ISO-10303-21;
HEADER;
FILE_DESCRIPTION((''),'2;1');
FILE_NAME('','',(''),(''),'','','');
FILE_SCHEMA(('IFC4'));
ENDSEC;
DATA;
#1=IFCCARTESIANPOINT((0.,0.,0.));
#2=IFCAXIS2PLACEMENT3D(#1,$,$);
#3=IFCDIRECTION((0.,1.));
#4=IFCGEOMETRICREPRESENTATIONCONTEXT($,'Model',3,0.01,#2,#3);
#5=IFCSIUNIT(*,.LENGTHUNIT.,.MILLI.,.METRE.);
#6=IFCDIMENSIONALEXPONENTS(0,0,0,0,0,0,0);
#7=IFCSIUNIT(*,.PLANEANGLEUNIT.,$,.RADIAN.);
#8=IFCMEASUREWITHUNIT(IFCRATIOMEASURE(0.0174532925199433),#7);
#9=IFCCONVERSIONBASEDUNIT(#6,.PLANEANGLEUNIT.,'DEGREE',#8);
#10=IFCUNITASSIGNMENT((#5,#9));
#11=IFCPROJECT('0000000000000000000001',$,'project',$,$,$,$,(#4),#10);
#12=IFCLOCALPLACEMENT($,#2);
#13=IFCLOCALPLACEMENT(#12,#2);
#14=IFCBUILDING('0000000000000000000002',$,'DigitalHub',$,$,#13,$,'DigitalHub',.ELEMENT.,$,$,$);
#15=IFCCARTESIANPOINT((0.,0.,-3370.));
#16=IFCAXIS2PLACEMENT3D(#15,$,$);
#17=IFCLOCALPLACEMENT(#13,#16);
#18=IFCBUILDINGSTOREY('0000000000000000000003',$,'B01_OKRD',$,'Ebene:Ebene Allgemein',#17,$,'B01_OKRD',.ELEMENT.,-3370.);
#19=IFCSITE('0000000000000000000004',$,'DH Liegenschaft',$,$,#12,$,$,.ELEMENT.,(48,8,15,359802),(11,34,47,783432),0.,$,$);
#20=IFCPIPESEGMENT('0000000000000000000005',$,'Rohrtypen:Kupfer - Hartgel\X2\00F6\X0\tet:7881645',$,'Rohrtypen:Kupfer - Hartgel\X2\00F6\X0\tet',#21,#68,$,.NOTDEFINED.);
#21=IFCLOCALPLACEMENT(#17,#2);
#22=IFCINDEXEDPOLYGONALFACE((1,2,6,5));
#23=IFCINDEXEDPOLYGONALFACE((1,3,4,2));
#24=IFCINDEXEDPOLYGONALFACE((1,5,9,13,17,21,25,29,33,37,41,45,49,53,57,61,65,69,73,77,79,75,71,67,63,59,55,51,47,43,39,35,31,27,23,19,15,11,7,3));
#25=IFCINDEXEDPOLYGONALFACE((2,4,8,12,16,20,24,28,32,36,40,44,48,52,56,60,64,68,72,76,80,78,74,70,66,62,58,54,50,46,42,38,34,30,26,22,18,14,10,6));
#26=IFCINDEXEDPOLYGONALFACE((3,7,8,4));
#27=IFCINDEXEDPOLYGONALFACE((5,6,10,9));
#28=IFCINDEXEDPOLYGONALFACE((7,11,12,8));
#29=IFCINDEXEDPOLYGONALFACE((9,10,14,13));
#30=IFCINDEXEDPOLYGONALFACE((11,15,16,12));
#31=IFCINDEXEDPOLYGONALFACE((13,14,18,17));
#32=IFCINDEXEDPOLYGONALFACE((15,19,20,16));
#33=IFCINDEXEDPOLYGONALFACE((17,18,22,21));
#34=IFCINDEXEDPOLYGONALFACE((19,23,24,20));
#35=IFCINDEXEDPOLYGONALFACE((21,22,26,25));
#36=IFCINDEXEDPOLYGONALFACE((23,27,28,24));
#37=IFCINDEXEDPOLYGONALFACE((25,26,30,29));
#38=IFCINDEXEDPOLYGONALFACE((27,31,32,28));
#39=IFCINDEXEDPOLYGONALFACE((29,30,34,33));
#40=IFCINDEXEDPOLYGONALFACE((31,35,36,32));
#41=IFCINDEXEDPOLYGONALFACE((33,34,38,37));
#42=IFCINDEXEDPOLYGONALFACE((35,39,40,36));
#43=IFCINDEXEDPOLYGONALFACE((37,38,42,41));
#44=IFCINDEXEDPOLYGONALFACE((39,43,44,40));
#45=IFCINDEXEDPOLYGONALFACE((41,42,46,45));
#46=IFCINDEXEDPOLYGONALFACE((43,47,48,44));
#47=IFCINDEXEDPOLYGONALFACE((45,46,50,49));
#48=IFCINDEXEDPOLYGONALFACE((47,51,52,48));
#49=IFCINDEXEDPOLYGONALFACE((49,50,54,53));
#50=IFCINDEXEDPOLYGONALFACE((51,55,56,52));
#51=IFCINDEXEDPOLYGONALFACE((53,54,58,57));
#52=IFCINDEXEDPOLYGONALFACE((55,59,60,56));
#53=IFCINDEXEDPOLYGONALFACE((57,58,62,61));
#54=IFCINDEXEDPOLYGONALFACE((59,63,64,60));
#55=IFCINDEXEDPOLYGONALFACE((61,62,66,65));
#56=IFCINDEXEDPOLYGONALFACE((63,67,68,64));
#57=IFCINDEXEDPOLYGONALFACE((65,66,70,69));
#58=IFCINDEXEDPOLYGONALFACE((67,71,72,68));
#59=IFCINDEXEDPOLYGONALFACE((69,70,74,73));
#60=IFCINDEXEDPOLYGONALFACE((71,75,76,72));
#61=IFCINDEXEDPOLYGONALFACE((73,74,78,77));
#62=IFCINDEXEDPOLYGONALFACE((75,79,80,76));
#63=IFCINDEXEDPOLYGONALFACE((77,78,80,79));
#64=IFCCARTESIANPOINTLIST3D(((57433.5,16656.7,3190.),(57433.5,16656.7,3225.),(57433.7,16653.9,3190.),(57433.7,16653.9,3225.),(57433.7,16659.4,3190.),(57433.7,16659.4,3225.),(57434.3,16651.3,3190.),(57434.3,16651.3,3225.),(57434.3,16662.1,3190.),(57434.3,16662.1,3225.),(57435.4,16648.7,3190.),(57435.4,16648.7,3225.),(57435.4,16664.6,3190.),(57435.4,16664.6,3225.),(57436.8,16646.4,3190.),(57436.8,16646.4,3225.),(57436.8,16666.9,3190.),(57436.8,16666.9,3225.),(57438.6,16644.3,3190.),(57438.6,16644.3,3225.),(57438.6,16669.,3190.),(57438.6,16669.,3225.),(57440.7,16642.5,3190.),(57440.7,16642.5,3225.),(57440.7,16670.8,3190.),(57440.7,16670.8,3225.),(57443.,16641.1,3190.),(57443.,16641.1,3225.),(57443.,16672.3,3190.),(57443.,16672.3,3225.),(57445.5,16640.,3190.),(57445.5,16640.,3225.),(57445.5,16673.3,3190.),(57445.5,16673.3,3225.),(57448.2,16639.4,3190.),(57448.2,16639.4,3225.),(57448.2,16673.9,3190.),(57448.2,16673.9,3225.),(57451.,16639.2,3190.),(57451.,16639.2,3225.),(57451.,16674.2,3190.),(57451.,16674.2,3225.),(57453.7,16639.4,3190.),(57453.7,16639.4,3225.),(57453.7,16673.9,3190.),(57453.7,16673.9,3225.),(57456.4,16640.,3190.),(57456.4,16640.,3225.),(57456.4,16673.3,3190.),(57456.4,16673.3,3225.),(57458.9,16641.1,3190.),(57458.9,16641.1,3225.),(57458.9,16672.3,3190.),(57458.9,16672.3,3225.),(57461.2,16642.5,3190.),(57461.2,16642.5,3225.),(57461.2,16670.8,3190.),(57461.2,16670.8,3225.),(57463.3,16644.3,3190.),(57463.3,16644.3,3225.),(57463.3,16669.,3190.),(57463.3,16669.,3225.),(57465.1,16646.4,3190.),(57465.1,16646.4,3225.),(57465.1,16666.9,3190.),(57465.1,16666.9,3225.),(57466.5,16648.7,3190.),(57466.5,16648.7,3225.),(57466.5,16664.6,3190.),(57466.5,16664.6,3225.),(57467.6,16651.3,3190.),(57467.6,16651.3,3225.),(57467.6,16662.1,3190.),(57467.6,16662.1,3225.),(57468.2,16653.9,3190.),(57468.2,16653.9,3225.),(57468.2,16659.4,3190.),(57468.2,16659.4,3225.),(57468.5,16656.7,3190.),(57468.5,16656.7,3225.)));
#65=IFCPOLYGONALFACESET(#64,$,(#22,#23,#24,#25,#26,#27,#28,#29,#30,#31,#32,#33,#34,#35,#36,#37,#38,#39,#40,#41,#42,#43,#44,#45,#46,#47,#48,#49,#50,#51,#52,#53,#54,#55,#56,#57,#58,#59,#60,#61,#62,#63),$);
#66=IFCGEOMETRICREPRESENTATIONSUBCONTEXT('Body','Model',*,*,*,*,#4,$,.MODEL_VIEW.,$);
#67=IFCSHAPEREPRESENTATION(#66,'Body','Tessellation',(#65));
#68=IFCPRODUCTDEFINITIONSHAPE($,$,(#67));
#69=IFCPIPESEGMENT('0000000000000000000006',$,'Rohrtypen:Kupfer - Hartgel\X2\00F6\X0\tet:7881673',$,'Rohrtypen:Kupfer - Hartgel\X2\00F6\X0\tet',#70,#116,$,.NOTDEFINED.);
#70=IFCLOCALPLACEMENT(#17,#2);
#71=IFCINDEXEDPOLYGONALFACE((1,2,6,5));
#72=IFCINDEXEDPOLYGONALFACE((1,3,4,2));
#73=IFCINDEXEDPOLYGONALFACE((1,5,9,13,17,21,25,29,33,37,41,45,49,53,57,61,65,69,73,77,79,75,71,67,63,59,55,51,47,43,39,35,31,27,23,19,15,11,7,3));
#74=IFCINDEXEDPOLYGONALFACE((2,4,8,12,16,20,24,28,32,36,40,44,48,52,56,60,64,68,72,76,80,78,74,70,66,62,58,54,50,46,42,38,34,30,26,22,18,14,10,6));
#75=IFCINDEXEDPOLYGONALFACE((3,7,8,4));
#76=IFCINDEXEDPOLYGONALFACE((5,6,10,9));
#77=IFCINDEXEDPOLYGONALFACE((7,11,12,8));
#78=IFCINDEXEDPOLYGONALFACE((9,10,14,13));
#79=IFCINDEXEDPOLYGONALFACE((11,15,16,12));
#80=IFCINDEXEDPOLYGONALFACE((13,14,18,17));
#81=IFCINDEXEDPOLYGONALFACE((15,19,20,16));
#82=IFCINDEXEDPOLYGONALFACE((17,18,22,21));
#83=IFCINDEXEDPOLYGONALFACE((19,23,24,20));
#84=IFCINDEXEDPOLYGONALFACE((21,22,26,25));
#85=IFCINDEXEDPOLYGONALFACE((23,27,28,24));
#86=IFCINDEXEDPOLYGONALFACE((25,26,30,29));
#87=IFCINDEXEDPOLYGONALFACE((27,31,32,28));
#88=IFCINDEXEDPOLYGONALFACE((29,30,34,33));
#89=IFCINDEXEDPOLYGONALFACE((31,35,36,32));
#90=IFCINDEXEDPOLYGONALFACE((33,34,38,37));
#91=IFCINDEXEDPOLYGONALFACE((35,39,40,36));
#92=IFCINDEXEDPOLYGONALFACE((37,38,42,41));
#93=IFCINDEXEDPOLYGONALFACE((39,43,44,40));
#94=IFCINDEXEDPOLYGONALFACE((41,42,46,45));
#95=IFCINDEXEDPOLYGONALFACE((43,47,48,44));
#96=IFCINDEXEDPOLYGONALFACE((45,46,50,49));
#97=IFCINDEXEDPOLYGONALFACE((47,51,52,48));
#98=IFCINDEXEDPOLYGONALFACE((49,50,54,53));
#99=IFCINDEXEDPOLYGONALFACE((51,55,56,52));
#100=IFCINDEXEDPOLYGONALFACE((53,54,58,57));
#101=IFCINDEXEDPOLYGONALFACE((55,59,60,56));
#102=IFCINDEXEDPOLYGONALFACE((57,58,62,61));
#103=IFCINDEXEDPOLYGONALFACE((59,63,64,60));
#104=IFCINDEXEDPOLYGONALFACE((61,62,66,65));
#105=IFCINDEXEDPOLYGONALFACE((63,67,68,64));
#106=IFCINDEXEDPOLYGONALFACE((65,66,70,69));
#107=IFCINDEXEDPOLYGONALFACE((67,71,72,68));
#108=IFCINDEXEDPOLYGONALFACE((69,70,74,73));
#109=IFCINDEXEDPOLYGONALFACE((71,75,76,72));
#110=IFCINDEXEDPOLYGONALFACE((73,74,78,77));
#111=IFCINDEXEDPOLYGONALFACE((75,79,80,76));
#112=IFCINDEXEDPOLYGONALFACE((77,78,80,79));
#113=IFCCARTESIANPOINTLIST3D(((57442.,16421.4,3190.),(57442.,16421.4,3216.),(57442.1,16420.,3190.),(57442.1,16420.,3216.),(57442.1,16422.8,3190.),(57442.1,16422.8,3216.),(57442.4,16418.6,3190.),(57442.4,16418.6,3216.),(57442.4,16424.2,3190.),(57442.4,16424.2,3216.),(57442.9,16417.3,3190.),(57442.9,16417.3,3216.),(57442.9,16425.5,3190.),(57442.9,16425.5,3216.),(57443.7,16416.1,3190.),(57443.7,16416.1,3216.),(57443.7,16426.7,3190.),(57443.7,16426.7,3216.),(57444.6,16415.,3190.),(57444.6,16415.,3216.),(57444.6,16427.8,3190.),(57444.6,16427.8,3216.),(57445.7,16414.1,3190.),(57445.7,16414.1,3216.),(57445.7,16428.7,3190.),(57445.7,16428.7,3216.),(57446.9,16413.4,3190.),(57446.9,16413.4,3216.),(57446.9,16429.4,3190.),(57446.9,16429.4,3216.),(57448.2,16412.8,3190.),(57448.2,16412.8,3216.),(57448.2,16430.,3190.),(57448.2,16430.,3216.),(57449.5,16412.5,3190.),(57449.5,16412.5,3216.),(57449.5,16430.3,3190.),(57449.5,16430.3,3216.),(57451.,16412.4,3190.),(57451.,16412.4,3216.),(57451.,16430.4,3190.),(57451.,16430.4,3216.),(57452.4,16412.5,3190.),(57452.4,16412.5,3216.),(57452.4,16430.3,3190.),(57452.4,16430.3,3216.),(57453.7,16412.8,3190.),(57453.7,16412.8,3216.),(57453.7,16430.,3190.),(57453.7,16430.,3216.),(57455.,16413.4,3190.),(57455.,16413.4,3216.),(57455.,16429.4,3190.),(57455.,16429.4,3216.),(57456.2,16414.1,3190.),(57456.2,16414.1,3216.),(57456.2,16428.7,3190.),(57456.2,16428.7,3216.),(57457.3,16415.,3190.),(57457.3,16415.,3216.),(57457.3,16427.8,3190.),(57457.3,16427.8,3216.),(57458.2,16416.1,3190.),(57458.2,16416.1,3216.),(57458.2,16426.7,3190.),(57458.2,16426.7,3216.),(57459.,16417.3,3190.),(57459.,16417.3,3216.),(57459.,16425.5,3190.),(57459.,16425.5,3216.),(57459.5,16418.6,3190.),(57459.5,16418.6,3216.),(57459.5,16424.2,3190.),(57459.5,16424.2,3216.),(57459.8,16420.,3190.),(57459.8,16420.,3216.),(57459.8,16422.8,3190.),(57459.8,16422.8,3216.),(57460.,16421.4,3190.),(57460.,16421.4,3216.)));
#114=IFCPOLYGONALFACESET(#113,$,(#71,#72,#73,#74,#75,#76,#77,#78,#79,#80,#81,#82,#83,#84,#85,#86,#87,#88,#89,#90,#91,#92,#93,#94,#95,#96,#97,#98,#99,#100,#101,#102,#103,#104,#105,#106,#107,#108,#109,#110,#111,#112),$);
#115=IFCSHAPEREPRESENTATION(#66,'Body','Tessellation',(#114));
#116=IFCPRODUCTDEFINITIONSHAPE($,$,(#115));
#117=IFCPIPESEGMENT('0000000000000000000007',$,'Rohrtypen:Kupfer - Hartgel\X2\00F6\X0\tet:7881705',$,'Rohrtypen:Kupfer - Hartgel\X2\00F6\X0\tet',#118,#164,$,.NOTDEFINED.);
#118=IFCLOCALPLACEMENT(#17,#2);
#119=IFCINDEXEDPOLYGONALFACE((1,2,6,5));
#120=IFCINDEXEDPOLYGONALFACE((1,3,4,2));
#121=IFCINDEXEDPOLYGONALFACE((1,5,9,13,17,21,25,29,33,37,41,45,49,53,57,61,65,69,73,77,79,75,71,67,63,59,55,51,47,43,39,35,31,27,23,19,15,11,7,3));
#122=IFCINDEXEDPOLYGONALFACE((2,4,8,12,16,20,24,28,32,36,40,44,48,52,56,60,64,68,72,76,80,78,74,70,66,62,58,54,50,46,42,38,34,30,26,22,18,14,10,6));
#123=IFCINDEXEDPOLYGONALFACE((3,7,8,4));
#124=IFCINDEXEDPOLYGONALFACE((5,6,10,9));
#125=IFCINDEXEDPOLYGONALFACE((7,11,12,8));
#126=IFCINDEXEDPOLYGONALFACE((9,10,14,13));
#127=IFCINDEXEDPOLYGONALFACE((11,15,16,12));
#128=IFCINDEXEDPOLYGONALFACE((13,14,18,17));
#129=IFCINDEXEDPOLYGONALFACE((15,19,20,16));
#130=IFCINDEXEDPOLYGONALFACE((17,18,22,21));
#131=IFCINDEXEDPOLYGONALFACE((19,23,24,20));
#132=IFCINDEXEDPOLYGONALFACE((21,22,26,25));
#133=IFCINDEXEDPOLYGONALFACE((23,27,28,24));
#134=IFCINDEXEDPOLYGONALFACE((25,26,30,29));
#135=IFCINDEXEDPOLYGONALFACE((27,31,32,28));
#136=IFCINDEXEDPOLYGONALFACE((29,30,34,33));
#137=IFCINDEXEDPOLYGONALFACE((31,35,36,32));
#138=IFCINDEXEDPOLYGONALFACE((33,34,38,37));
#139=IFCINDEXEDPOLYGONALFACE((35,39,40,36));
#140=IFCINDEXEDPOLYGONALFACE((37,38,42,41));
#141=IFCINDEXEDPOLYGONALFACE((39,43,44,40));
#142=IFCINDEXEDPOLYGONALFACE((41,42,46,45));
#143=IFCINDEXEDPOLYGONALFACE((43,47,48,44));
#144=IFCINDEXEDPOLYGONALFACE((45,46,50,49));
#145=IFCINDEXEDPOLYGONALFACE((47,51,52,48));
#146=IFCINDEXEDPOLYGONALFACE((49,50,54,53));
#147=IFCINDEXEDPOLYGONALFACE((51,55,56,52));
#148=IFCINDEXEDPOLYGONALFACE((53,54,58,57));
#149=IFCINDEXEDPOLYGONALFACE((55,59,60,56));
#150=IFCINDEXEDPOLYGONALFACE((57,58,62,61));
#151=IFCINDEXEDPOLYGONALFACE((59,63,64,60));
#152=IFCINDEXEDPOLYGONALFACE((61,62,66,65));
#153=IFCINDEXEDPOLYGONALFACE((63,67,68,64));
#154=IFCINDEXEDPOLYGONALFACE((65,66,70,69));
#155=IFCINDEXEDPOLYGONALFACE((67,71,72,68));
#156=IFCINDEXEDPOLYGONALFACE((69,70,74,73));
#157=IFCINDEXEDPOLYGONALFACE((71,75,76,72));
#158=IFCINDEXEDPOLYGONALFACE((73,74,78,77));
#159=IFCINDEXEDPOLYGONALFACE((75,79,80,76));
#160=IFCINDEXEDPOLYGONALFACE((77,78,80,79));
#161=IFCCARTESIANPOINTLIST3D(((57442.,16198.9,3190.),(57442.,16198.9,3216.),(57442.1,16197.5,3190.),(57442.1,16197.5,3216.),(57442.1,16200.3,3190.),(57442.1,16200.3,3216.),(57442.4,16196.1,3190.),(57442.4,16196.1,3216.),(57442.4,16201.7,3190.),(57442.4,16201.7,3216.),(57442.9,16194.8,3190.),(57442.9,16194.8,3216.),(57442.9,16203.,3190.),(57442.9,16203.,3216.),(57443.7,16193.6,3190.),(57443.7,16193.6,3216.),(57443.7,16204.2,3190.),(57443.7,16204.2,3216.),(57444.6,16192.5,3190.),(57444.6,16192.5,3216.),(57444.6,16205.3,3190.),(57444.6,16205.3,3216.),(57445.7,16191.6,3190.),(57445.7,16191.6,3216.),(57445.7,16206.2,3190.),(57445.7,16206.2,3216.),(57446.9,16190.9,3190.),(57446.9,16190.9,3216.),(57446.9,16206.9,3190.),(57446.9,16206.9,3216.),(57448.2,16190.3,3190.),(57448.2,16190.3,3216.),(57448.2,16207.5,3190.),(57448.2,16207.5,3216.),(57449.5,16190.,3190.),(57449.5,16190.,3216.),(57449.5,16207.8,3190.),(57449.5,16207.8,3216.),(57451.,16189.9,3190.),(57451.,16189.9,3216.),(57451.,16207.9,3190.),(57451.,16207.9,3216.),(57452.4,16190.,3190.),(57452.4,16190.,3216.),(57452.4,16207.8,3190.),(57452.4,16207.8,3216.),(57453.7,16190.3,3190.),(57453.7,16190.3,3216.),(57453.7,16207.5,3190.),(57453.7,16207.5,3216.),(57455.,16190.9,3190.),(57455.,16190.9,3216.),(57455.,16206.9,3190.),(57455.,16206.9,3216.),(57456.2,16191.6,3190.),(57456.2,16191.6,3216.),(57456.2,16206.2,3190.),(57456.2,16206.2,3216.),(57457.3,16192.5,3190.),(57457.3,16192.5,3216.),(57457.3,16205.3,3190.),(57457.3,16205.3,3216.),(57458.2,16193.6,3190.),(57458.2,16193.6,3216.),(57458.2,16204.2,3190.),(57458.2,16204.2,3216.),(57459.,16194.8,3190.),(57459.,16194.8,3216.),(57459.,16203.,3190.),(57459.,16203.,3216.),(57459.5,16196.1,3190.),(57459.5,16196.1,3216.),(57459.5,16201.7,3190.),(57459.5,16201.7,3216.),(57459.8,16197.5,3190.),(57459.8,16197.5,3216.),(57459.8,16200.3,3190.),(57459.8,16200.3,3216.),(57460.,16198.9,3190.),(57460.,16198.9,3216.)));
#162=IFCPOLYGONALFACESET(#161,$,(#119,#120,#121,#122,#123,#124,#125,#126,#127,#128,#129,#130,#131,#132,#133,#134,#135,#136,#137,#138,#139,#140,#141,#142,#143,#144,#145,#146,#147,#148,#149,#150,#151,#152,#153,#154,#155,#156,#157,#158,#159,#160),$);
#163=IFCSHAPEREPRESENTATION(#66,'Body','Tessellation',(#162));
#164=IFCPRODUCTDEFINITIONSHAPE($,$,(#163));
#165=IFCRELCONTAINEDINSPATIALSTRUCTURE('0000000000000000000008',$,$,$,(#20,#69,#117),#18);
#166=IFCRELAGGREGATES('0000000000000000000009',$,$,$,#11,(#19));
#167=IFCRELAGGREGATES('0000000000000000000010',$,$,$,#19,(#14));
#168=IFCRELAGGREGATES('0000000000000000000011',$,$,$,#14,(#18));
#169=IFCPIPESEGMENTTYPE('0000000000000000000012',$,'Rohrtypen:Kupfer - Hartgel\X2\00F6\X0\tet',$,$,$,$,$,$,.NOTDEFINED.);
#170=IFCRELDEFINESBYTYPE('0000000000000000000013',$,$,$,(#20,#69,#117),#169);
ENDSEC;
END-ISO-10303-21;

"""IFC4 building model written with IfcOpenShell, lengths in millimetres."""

from ifc_helpers import new_model, entity, si_unit, converted_unit, direction, frame, origin, place, context, subcontext, project, spatial, indexed_curve, outline, extrude, type_object, element, save


model = new_model("IFC4")

# Units and contexts
model_context = context("Model", 3, precision=0.01, world=origin(), true_north=direction((0.0, 1.0)))
body_context = subcontext(model_context, "Body", "Model", "MODEL_VIEW")
ifc_project = project(units=[si_unit("LENGTHUNIT", "METRE", prefix="MILLI"), converted_unit("PLANEANGLEUNIT", "DEGREE", entity("IfcRatioMeasure", 0.0174532925199433), si_unit("PLANEANGLEUNIT", "RADIAN"), dimensions=[0, 0, 0, 0, 0, 0, 0])], contexts=[model_context])

# Site, building, storey
site_placement = place(None, origin())
site = spatial("IfcSite", under=ifc_project, at=site_placement, Name="DH Liegenschaft", CompositionType="ELEMENT", RefLatitude=(48, 8, 15, 359802), RefLongitude=(11, 34, 47, 783432), RefElevation=0.0)
building_placement = place(site_placement, origin())
building = spatial("IfcBuilding", under=site, at=building_placement, Name="DigitalHub", LongName="DigitalHub", CompositionType="ELEMENT")
storey_placement = place(building_placement, frame((0.0, 0.0, -3370.0)))
storey = spatial("IfcBuildingStorey", under=building, at=storey_placement, Name="B01_OKRD", ObjectType="Ebene:Ebene Allgemein", LongName="B01_OKRD", CompositionType="ELEMENT", Elevation=-3370.0)

# Pipe segments
pipe_segment_type = type_object("IfcPipeSegmentType", Name="Rohrtypen:Kupfer - Hartgelötet", PredefinedType="NOTDEFINED")
pipe_segment_1_placement = place(storey_placement, frame((57431.9, 16637.6, 3190.0)))
element("IfcPipeSegment", 1, at=pipe_segment_1_placement, inside=storey, type_object=pipe_segment_type, Name="Rohrtypen:Kupfer - Hartgelötet:7881645", ObjectType="Rohrtypen:Kupfer - Hartgelötet", PredefinedType="NOTDEFINED", context=body_context, shape_type="SweptSolid", body=[
    extrude(outline(indexed_curve([(17.5, 0.0), (17.3, 2.7), (16.6, 5.4), (15.6, 7.9), (14.2, 10.3), (12.4, 12.4), (10.3, 14.2), (7.9, 15.6), (5.4, 16.6), (2.7, 17.3), (0.0, 17.5), (-2.7, 17.3), (-5.4, 16.6), (-7.9, 15.6), (-10.3, 14.2), (-12.4, 12.4), (-14.2, 10.3), (-15.6, 7.9), (-16.6, 5.4), (-17.3, 2.7), (-17.5, 0.0), (-17.3, -2.7), (-16.6, -5.4), (-15.6, -7.9), (-14.2, -10.3), (-12.4, -12.4), (-10.3, -14.2), (-7.9, -15.6), (-5.4, -16.6), (-2.7, -17.3), (0.0, -17.5), (2.7, -17.3), (5.4, -16.6), (7.9, -15.6), (10.3, -14.2), (12.4, -12.4), (14.2, -10.3), (15.6, -7.9), (16.6, -5.4), (17.3, -2.7), (17.5, 0.0)], self_intersect=False)), frame((19.1, 19.1, 0.0), z_axis=(0.0, 0.0, 1.0), x_axis=(-1.0, 0.0, 0.0)), (0.0, 0.0, 1.0), 35.0),
])
pipe_segment_2_placement = place(storey_placement, frame((57440.4, 16410.8, 3190.0)))
element("IfcPipeSegment", 2, at=pipe_segment_2_placement, inside=storey, type_object=pipe_segment_type, Name="Rohrtypen:Kupfer - Hartgelötet:7881673", ObjectType="Rohrtypen:Kupfer - Hartgelötet", PredefinedType="NOTDEFINED", context=body_context, shape_type="SweptSolid", body=[
    extrude(outline(indexed_curve([(9.0, 0.0), (8.9, 1.4), (8.6, 2.8), (8.0, 4.1), (7.3, 5.3), (6.4, 6.4), (5.3, 7.3), (4.1, 8.0), (2.8, 8.6), (1.4, 8.9), (0.0, 9.0), (-1.4, 8.9), (-2.8, 8.6), (-4.1, 8.0), (-5.3, 7.3), (-6.4, 6.4), (-7.3, 5.3), (-8.0, 4.1), (-8.6, 2.8), (-8.9, 1.4), (-9.0, 0.0), (-8.9, -1.4), (-8.6, -2.8), (-8.0, -4.1), (-7.3, -5.3), (-6.4, -6.4), (-5.3, -7.3), (-4.1, -8.0), (-2.8, -8.6), (-1.4, -8.9), (0.0, -9.0), (1.4, -8.9), (2.8, -8.6), (4.1, -8.0), (5.3, -7.3), (6.4, -6.4), (7.3, -5.3), (8.0, -4.1), (8.6, -2.8), (8.9, -1.4), (9.0, 0.0)], self_intersect=False)), frame((10.6, 10.6, 0.0)), (0.0, 0.0, 1.0), 26.0),
])
pipe_segment_3_placement = place(storey_placement, frame((57440.4, 16188.3, 3190.0)))
element("IfcPipeSegment", 3, at=pipe_segment_3_placement, inside=storey, type_object=pipe_segment_type, Name="Rohrtypen:Kupfer - Hartgelötet:7881705", ObjectType="Rohrtypen:Kupfer - Hartgelötet", PredefinedType="NOTDEFINED", context=body_context, shape_type="SweptSolid", body=[
    extrude(outline(indexed_curve([(9.0, 0.0), (8.9, 1.4), (8.6, 2.8), (8.0, 4.1), (7.3, 5.3), (6.4, 6.4), (5.3, 7.3), (4.1, 8.0), (2.8, 8.6), (1.4, 8.9), (0.0, 9.0), (-1.4, 8.9), (-2.8, 8.6), (-4.1, 8.0), (-5.3, 7.3), (-6.4, 6.4), (-7.3, 5.3), (-8.0, 4.1), (-8.6, 2.8), (-8.9, 1.4), (-9.0, 0.0), (-8.9, -1.4), (-8.6, -2.8), (-8.0, -4.1), (-7.3, -5.3), (-6.4, -6.4), (-5.3, -7.3), (-4.1, -8.0), (-2.8, -8.6), (-1.4, -8.9), (0.0, -9.0), (1.4, -8.9), (2.8, -8.6), (4.1, -8.0), (5.3, -7.3), (6.4, -6.4), (7.3, -5.3), (8.0, -4.1), (8.6, -2.8), (8.9, -1.4), (9.0, 0.0)], self_intersect=False)), frame((10.6, 10.6, 0.0)), (0.0, 0.0, 1.0), 26.0),
])

save(model, "model.ifc")
